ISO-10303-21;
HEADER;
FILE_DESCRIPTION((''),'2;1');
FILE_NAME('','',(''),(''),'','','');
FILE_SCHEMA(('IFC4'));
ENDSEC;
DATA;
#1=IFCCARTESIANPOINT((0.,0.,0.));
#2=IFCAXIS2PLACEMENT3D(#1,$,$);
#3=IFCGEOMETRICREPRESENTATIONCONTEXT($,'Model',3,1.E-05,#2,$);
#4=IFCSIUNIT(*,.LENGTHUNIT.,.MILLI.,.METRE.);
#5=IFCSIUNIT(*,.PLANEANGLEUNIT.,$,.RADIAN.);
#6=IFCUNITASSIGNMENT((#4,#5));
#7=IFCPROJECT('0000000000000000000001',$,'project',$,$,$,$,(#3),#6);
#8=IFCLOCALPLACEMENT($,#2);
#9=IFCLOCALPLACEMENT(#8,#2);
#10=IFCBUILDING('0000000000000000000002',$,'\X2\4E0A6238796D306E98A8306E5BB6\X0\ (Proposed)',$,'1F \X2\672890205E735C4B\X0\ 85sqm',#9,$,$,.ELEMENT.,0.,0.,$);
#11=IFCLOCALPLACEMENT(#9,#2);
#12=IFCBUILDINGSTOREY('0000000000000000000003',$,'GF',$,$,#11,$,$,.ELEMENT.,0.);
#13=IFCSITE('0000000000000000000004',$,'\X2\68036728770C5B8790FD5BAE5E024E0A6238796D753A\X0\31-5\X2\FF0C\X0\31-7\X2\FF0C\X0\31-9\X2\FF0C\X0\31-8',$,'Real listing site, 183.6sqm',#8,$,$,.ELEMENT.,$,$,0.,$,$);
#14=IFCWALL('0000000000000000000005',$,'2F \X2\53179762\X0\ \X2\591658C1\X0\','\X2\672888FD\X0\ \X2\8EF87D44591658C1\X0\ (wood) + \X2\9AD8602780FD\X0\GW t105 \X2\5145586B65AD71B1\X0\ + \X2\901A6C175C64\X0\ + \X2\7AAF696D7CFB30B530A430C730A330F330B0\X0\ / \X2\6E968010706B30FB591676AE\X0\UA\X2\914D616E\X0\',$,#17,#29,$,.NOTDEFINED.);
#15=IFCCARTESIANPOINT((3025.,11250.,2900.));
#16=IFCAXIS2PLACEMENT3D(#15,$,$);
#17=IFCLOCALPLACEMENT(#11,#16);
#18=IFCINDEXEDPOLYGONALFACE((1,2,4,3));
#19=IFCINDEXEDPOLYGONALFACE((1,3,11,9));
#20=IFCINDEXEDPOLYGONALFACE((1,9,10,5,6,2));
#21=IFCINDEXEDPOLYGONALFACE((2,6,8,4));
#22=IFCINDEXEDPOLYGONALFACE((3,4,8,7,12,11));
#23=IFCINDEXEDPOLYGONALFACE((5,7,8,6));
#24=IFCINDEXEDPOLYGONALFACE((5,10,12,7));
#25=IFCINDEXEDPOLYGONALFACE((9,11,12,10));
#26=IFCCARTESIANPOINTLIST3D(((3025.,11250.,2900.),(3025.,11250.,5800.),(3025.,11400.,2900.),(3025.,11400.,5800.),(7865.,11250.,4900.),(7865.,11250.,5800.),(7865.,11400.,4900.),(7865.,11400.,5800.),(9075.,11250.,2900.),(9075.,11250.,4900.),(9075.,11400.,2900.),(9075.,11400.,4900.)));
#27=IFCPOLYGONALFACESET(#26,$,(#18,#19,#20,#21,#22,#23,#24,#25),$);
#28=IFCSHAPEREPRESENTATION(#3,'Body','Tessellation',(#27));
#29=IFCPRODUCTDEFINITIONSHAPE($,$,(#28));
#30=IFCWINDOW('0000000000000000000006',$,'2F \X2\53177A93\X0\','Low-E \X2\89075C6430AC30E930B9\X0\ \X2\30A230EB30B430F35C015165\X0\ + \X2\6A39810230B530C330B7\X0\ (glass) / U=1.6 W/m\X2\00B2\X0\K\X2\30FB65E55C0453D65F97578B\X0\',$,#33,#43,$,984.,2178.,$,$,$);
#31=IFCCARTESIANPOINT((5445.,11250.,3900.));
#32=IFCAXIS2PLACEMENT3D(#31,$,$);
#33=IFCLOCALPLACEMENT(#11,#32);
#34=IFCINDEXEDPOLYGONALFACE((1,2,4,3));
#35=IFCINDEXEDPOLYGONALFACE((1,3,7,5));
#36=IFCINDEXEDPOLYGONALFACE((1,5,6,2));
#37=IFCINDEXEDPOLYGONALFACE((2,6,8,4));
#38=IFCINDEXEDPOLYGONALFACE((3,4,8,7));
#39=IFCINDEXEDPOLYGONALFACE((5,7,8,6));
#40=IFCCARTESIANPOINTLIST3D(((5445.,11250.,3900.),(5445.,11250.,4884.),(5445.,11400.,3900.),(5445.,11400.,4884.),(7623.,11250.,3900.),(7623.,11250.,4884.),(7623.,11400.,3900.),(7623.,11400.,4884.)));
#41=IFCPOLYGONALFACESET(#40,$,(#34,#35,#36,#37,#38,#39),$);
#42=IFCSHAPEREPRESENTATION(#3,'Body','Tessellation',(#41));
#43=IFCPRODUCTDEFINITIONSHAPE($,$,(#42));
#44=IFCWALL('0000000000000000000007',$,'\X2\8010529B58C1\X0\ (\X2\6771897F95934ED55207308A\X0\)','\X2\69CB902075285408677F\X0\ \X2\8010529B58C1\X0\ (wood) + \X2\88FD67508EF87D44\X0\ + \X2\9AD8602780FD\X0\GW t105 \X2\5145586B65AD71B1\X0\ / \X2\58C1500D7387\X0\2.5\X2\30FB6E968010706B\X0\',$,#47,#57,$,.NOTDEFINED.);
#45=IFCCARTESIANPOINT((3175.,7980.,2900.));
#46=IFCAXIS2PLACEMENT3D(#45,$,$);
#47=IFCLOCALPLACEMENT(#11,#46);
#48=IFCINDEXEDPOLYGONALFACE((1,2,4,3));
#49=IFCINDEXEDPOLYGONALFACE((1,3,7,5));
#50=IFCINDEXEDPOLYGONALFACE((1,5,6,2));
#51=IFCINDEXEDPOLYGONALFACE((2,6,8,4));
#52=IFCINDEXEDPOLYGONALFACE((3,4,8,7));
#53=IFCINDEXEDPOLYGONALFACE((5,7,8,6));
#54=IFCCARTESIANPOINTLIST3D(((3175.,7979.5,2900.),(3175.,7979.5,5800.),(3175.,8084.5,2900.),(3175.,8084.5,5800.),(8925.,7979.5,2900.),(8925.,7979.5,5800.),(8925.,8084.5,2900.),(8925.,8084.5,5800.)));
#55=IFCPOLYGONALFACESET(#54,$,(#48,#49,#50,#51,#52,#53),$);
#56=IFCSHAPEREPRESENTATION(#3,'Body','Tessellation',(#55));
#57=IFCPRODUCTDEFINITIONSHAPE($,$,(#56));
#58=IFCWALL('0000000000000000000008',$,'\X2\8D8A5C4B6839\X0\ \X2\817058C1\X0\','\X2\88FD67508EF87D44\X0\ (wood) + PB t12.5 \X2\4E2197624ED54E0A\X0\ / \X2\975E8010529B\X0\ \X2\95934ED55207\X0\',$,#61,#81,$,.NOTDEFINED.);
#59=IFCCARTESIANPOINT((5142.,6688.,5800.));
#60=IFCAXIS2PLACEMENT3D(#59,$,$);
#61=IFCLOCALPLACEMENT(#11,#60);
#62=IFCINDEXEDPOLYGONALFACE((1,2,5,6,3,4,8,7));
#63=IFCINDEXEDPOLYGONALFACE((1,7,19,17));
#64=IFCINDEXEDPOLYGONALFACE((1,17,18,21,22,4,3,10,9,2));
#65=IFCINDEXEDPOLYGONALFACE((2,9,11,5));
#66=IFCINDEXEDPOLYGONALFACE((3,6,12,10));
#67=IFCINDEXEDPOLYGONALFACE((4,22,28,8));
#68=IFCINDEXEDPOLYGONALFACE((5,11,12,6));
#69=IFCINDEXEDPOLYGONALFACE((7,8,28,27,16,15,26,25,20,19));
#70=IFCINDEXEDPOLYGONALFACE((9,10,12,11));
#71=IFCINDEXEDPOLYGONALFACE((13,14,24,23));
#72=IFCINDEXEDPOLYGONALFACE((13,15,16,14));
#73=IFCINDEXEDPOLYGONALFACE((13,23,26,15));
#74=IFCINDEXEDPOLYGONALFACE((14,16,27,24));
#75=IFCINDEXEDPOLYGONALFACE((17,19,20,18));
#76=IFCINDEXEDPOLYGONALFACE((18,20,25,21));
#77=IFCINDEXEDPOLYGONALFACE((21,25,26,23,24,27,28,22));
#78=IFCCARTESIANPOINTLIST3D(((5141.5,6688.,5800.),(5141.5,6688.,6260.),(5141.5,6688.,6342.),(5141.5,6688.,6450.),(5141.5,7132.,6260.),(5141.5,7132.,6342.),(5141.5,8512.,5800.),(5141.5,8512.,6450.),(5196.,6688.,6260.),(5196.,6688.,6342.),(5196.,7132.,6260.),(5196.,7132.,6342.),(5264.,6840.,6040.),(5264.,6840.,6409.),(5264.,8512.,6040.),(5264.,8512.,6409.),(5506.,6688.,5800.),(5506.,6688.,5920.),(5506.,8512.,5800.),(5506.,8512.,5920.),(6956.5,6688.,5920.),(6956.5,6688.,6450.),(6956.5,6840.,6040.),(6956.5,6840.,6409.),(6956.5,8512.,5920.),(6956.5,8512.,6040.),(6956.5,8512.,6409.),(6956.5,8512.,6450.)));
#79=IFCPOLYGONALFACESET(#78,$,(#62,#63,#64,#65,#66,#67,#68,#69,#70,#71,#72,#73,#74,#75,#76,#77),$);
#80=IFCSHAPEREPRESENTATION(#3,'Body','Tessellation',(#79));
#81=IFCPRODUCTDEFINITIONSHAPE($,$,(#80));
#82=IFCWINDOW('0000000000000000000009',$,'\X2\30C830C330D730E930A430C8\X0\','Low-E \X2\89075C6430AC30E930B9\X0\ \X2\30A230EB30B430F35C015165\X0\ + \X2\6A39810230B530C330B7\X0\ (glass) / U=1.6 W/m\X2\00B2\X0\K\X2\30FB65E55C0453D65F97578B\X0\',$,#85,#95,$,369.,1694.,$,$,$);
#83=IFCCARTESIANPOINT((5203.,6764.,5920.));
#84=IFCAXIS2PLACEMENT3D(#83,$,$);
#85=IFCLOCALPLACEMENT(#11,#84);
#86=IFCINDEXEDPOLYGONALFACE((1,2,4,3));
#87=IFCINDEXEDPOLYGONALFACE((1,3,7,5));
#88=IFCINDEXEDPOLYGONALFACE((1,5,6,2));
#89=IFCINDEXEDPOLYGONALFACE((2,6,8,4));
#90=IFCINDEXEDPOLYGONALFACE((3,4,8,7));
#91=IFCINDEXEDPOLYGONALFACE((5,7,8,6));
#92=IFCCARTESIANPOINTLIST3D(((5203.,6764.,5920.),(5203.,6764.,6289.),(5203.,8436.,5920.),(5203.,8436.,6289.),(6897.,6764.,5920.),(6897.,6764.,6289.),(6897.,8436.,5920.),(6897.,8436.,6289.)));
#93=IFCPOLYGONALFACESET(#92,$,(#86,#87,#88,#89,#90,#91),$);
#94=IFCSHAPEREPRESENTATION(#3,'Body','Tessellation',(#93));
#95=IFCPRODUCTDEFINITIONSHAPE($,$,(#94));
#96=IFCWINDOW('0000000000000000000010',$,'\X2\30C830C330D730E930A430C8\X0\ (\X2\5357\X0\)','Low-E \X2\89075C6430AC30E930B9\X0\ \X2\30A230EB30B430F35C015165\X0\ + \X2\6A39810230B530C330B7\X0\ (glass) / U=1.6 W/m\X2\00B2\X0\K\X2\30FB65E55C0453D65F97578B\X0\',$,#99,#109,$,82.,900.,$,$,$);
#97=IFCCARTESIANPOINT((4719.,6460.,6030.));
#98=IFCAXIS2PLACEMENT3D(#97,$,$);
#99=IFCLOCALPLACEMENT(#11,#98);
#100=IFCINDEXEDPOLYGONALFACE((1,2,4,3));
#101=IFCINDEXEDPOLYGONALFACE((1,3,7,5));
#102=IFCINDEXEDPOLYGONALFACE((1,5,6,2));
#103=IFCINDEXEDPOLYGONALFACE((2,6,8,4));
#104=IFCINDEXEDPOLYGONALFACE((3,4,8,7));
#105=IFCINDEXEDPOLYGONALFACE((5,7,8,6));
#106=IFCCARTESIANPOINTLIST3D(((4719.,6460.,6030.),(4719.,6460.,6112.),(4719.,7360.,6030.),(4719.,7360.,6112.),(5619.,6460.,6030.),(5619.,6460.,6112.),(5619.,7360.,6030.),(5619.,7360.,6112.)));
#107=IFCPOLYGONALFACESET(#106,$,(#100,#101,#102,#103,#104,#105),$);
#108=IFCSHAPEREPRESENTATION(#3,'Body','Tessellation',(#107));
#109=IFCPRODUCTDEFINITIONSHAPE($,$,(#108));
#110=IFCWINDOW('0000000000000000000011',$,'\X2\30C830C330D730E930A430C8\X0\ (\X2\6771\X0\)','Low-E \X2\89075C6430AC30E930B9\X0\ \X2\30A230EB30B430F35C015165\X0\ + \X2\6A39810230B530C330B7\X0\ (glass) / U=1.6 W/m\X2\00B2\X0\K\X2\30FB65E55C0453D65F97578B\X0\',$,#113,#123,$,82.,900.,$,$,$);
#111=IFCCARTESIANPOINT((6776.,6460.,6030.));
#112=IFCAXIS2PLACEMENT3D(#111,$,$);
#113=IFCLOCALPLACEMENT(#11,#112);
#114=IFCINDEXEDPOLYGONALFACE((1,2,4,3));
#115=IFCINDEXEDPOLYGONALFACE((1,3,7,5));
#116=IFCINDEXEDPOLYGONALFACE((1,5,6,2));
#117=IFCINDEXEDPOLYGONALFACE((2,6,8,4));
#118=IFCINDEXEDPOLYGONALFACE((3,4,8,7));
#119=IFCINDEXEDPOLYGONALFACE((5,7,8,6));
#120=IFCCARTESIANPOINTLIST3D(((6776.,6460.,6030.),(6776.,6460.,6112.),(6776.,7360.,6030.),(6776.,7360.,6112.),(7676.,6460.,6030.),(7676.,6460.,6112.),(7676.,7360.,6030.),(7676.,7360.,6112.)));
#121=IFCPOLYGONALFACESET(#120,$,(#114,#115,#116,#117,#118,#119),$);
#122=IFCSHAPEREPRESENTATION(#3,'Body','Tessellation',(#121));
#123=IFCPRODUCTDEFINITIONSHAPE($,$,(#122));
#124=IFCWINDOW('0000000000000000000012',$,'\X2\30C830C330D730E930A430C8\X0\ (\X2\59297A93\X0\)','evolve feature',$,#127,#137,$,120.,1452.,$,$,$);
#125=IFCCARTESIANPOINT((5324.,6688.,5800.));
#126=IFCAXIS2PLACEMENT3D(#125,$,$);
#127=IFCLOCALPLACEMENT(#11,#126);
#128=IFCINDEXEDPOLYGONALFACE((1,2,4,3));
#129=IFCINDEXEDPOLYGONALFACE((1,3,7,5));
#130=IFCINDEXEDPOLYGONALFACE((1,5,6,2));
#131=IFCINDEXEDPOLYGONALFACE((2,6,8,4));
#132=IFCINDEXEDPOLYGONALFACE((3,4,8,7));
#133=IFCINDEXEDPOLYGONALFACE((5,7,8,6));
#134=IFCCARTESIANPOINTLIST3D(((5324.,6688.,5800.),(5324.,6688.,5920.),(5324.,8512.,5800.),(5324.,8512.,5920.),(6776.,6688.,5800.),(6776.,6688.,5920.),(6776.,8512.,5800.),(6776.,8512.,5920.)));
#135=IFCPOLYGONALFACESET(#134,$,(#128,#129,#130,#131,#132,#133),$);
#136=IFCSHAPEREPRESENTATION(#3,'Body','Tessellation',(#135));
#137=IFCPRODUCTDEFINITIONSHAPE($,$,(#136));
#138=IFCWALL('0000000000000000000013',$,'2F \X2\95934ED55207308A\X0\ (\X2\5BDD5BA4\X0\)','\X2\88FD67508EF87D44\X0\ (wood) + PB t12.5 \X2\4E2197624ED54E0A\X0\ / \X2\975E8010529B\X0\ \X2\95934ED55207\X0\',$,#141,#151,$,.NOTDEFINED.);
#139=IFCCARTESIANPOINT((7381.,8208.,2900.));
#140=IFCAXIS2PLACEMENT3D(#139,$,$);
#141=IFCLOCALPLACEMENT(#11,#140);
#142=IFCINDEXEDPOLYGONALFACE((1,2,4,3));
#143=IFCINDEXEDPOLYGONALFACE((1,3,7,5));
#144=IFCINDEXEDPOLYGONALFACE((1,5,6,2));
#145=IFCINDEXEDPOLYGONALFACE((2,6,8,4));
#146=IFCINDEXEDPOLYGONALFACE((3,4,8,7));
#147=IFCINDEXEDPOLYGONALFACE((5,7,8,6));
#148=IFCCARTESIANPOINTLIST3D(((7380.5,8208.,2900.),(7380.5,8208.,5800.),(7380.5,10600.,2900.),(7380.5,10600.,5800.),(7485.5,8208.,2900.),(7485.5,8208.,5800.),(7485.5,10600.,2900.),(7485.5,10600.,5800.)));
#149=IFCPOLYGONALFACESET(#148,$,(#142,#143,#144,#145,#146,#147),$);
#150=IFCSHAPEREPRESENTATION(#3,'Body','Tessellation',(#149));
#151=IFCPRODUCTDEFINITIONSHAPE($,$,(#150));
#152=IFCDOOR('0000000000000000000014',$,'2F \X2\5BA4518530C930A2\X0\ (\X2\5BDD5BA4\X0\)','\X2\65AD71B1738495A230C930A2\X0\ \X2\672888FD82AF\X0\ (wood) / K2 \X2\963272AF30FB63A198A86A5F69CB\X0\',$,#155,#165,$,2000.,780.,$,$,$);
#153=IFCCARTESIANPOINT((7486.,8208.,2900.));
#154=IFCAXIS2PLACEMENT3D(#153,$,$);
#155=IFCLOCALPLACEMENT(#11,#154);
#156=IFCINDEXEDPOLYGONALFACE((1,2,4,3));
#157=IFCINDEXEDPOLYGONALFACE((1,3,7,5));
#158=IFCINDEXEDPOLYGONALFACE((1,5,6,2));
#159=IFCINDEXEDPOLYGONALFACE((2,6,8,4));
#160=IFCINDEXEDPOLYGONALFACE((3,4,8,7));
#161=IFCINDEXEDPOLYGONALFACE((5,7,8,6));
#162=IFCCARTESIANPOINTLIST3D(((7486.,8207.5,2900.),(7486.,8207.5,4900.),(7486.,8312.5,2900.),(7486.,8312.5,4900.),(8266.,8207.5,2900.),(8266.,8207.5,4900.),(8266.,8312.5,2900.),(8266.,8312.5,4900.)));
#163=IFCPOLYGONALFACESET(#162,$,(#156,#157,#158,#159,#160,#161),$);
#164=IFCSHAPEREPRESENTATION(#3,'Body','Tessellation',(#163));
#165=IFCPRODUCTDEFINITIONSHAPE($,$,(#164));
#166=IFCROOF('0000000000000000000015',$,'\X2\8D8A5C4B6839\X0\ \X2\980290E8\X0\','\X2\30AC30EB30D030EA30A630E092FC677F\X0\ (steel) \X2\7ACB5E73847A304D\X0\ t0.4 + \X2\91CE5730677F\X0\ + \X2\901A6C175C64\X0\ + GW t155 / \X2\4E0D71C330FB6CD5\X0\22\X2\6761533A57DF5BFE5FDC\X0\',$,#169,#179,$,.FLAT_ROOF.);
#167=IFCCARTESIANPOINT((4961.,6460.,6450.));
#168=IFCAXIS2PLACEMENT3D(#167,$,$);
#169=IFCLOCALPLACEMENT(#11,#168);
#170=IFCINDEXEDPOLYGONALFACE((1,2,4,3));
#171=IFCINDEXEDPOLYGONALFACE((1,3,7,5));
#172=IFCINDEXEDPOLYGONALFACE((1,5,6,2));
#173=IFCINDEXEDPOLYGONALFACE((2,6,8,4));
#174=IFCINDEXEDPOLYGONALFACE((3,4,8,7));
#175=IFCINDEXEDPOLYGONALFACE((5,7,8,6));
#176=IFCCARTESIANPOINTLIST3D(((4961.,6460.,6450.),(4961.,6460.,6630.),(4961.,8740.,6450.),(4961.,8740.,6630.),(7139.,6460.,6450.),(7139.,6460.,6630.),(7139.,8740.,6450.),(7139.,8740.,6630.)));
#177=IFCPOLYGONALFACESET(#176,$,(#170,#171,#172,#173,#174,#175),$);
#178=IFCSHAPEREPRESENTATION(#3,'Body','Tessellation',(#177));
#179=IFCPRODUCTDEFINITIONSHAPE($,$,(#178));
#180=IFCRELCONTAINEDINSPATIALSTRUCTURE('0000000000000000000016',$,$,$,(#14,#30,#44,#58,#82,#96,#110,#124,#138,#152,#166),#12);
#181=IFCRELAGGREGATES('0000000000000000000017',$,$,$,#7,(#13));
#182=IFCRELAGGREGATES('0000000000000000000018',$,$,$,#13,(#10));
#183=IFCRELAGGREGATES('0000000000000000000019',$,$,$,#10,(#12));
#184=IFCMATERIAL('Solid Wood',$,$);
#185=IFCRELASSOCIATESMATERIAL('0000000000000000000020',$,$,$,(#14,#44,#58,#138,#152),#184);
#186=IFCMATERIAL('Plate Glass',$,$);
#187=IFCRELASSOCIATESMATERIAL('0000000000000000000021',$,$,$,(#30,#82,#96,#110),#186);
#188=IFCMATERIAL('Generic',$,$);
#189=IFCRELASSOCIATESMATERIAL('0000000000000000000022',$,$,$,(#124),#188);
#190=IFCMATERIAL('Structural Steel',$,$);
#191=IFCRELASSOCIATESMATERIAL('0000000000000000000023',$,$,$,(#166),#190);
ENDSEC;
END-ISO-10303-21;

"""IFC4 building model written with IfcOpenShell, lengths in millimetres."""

from ifc_helpers import new_model, si_unit, frame, frame_2d, origin, place, context, project, spatial, rectangle, extrude, material, element, fill, save


model = new_model("IFC4")

# Units and contexts
model_context = context("Model", 3, precision=1e-05, world=origin())
ifc_project = project(units=[si_unit("LENGTHUNIT", "METRE", prefix="MILLI"), si_unit("PLANEANGLEUNIT", "RADIAN")], contexts=[model_context])

# Site, building, storey
site_placement = place(None, origin())
site = spatial("IfcSite", under=ifc_project, at=site_placement, Name="栃木県宇都宮市上戸祭町31-5，31-7，31-9，31-8", ObjectType="Real listing site, 183.6sqm", CompositionType="ELEMENT", RefElevation=0.0)
building_placement = place(site_placement, origin())
building = spatial("IfcBuilding", under=site, at=building_placement, Name="上戸祭の風の家 (Proposed)", ObjectType="1F 木造平屋 85sqm", CompositionType="ELEMENT", ElevationOfRefHeight=0.0, ElevationOfTerrain=0.0)
storey_placement = place(building_placement, origin())
storey = spatial("IfcBuildingStorey", under=building, at=storey_placement, Name="GF", CompositionType="ELEMENT", Elevation=0.0)

# Wall, opening, window
ifc_material_1 = material(Name="Solid Wood")
wall_1_placement = place(storey_placement, frame((3025.0, 11250.0, 2900.0)))
wall_1 = element("IfcWall", 1, at=wall_1_placement, inside=storey, material=ifc_material_1, Name="2F 北面 外壁", Description="木製 軸組外壁 (wood) + 高性能GW t105 充填断熱 + 通気層 + 窯業系サイディング / 準耐火・外皮UA配慮", PredefinedType="NOTDEFINED", context=model_context, shape_type="SweptSolid", body=[
    extrude(rectangle(XDim=6050.0, YDim=150.0, at=frame_2d((3025.0, 75.0))), frame((3025.0, 11250.0, 2900.0)), (0.0, 0.0, 1.0), 2900.0),
])
opening_1_placement = place(storey_placement, frame((5445.0, 11250.0, 3900.0)))
opening_1 = element("IfcOpeningElement", 2, at=opening_1_placement, cuts=wall_1, PredefinedType="NOTDEFINED", context=model_context, shape_type="SweptSolid", body=[
    extrude(rectangle(XDim=2178.0, YDim=150.0, at=frame_2d((1089.0, 75.0))), frame((5445.0, 11250.0, 3900.0)), (0.0, 0.0, 1.0), 984.0),
])
ifc_material_2 = material(Name="Plate Glass")
window_1_placement = place(storey_placement, frame((5445.0, 11250.0, 3900.0)))
window_1 = element("IfcWindow", 3, at=window_1_placement, inside=storey, material=ifc_material_2, Name="2F 北窓", Description="Low-E 複層ガラス アルゴン封入 + 樹脂サッシ (glass) / U=1.6 W/m²K・日射取得型", OverallHeight=984.0, OverallWidth=2178.0, context=model_context, shape_type="SweptSolid", body=[
    extrude(rectangle(XDim=2178.0, YDim=150.0, at=frame_2d((1089.0, 75.0))), frame((5445.0, 11250.0, 3900.0)), (0.0, 0.0, 1.0), 984.0),
])
fill(opening_1, window_1)

# Wall
wall_2_placement = place(storey_placement, frame((3175.0, 7980.0, 2900.0)))
element("IfcWall", 4, at=wall_2_placement, inside=storey, material=ifc_material_1, Name="耐力壁 (東西間仕切り)", Description="構造用合板 耐力壁 (wood) + 製材軸組 + 高性能GW t105 充填断熱 / 壁倍率2.5・準耐火", PredefinedType="NOTDEFINED", context=model_context, shape_type="SweptSolid", body=[
    extrude(rectangle(XDim=5750.0, YDim=105.0, at=frame_2d((2875.0, 52.0))), frame((3175.0, 7980.0, 2900.0)), (0.0, 0.0, 1.0), 2900.0),
])

# Wall, openings, windows
wall_3_placement = place(storey_placement, frame((5142.0, 6688.0, 5800.0)))
wall_3 = element("IfcWall", 5, at=wall_3_placement, inside=storey, material=ifc_material_1, Name="越屋根 腰壁", Description="製材軸組 (wood) + PB t12.5 両面仕上 / 非耐力 間仕切", PredefinedType="NOTDEFINED", context=model_context, shape_type="SweptSolid", body=[
    extrude(rectangle(XDim=1815.0, YDim=1824.0, at=frame_2d((907.0, 912.0))), frame((5142.0, 6688.0, 5800.0)), (0.0, 0.0, 1.0), 650.0),
])
opening_2_placement = place(storey_placement, frame((5203.0, 6764.0, 5920.0)))
opening_2 = element("IfcOpeningElement", 6, at=opening_2_placement, cuts=wall_3, PredefinedType="NOTDEFINED", context=model_context, shape_type="SweptSolid", body=[
    extrude(rectangle(XDim=1694.0, YDim=1672.0, at=frame_2d((847.0, 836.0))), frame((5203.0, 6764.0, 5920.0)), (0.0, 0.0, 1.0), 369.0),
])
opening_3_placement = place(storey_placement, frame((4719.0, 6460.0, 6030.0)))
opening_3 = element("IfcOpeningElement", 7, at=opening_3_placement, cuts=wall_3, PredefinedType="NOTDEFINED", context=model_context, shape_type="SweptSolid", body=[
    extrude(rectangle(XDim=900.0, YDim=900.0, at=frame_2d((450.0, 450.0))), frame((4719.0, 6460.0, 6030.0)), (0.0, 0.0, 1.0), 82.0),
])
opening_4_placement = place(storey_placement, frame((6776.0, 6460.0, 6030.0)))
opening_4 = element("IfcOpeningElement", 8, at=opening_4_placement, cuts=wall_3, PredefinedType="NOTDEFINED", context=model_context, shape_type="SweptSolid", body=[
    extrude(rectangle(XDim=900.0, YDim=900.0, at=frame_2d((450.0, 450.0))), frame((6776.0, 6460.0, 6030.0)), (0.0, 0.0, 1.0), 82.0),
])
opening_5_placement = place(storey_placement, frame((5324.0, 6688.0, 5800.0)))
opening_5 = element("IfcOpeningElement", 9, at=opening_5_placement, cuts=wall_3, PredefinedType="NOTDEFINED", context=model_context, shape_type="SweptSolid", body=[
    extrude(rectangle(XDim=1452.0, YDim=1824.0, at=frame_2d((726.0, 912.0))), frame((5324.0, 6688.0, 5800.0)), (0.0, 0.0, 1.0), 120.0),
])
window_2_placement = place(storey_placement, frame((5203.0, 6764.0, 5920.0)))
window_2 = element("IfcWindow", 10, at=window_2_placement, inside=storey, material=ifc_material_2, Name="トップライト", Description="Low-E 複層ガラス アルゴン封入 + 樹脂サッシ (glass) / U=1.6 W/m²K・日射取得型", OverallHeight=369.0, OverallWidth=1694.0, context=model_context, shape_type="SweptSolid", body=[
    extrude(rectangle(XDim=1694.0, YDim=1672.0, at=frame_2d((847.0, 836.0))), frame((5203.0, 6764.0, 5920.0)), (0.0, 0.0, 1.0), 369.0),
])
fill(opening_2, window_2)
window_3_placement = place(storey_placement, frame((4719.0, 6460.0, 6030.0)))
window_3 = element("IfcWindow", 11, at=window_3_placement, inside=storey, material=ifc_material_2, Name="トップライト (南)", Description="Low-E 複層ガラス アルゴン封入 + 樹脂サッシ (glass) / U=1.6 W/m²K・日射取得型", OverallHeight=82.0, OverallWidth=900.0, context=model_context, shape_type="SweptSolid", body=[
    extrude(rectangle(XDim=900.0, YDim=900.0, at=frame_2d((450.0, 450.0))), frame((4719.0, 6460.0, 6030.0)), (0.0, 0.0, 1.0), 82.0),
])
fill(opening_3, window_3)
window_4_placement = place(storey_placement, frame((6776.0, 6460.0, 6030.0)))
window_4 = element("IfcWindow", 12, at=window_4_placement, inside=storey, material=ifc_material_2, Name="トップライト (東)", Description="Low-E 複層ガラス アルゴン封入 + 樹脂サッシ (glass) / U=1.6 W/m²K・日射取得型", OverallHeight=82.0, OverallWidth=900.0, context=model_context, shape_type="SweptSolid", body=[
    extrude(rectangle(XDim=900.0, YDim=900.0, at=frame_2d((450.0, 450.0))), frame((6776.0, 6460.0, 6030.0)), (0.0, 0.0, 1.0), 82.0),
])
fill(opening_4, window_4)
ifc_material_3 = material(Name="Generic")
window_5_placement = place(storey_placement, frame((5324.0, 6688.0, 5800.0)))
window_5 = element("IfcWindow", 13, at=window_5_placement, inside=storey, material=ifc_material_3, Name="トップライト (天窓)", Description="evolve feature", OverallHeight=120.0, OverallWidth=1452.0, context=model_context, shape_type="SweptSolid", body=[
    extrude(rectangle(XDim=1452.0, YDim=1824.0, at=frame_2d((726.0, 912.0))), frame((5324.0, 6688.0, 5800.0)), (0.0, 0.0, 1.0), 120.0),
])
fill(opening_5, window_5)

# Wall
wall_4_placement = place(storey_placement, frame((7381.0, 8208.0, 2900.0)))
element("IfcWall", 14, at=wall_4_placement, inside=storey, material=ifc_material_1, Name="2F 間仕切り (寝室)", Description="製材軸組 (wood) + PB t12.5 両面仕上 / 非耐力 間仕切", PredefinedType="NOTDEFINED", context=model_context, shape_type="SweptSolid", body=[
    extrude(rectangle(XDim=105.0, YDim=2392.0, at=frame_2d((52.0, 1196.0))), frame((7381.0, 8208.0, 2900.0)), (0.0, 0.0, 1.0), 2900.0),
])

# Door
door_placement = place(storey_placement, frame((7486.0, 8208.0, 2900.0)))
element("IfcDoor", 15, at=door_placement, inside=storey, material=ifc_material_1, Name="2F 室内ドア (寝室)", Description="断熱玄関ドア 木製芯 (wood) / K2 防犯・採風機構", OverallHeight=2000.0, OverallWidth=780.0, context=model_context, shape_type="SweptSolid", body=[
    extrude(rectangle(XDim=780.0, YDim=105.0, at=frame_2d((390.0, 52.0))), frame((7486.0, 8208.0, 2900.0)), (0.0, 0.0, 1.0), 2000.0),
])

# Roof
ifc_material_4 = material(Name="Structural Steel")
roof_placement = place(storey_placement, frame((4961.0, 6460.0, 6450.0)))
element("IfcRoof", 16, at=roof_placement, inside=storey, material=ifc_material_4, Name="越屋根 頂部", Description="ガルバリウム鋼板 (steel) 立平葺き t0.4 + 野地板 + 通気層 + GW t155 / 不燃・法22条区域対応", PredefinedType="FLAT_ROOF", context=model_context, shape_type="SweptSolid", body=[
    extrude(rectangle(XDim=2178.0, YDim=2280.0, at=frame_2d((1089.0, 1140.0))), frame((4961.0, 6460.0, 6450.0)), (0.0, 0.0, 1.0), 180.0),
])

save(model, "model.ifc")
